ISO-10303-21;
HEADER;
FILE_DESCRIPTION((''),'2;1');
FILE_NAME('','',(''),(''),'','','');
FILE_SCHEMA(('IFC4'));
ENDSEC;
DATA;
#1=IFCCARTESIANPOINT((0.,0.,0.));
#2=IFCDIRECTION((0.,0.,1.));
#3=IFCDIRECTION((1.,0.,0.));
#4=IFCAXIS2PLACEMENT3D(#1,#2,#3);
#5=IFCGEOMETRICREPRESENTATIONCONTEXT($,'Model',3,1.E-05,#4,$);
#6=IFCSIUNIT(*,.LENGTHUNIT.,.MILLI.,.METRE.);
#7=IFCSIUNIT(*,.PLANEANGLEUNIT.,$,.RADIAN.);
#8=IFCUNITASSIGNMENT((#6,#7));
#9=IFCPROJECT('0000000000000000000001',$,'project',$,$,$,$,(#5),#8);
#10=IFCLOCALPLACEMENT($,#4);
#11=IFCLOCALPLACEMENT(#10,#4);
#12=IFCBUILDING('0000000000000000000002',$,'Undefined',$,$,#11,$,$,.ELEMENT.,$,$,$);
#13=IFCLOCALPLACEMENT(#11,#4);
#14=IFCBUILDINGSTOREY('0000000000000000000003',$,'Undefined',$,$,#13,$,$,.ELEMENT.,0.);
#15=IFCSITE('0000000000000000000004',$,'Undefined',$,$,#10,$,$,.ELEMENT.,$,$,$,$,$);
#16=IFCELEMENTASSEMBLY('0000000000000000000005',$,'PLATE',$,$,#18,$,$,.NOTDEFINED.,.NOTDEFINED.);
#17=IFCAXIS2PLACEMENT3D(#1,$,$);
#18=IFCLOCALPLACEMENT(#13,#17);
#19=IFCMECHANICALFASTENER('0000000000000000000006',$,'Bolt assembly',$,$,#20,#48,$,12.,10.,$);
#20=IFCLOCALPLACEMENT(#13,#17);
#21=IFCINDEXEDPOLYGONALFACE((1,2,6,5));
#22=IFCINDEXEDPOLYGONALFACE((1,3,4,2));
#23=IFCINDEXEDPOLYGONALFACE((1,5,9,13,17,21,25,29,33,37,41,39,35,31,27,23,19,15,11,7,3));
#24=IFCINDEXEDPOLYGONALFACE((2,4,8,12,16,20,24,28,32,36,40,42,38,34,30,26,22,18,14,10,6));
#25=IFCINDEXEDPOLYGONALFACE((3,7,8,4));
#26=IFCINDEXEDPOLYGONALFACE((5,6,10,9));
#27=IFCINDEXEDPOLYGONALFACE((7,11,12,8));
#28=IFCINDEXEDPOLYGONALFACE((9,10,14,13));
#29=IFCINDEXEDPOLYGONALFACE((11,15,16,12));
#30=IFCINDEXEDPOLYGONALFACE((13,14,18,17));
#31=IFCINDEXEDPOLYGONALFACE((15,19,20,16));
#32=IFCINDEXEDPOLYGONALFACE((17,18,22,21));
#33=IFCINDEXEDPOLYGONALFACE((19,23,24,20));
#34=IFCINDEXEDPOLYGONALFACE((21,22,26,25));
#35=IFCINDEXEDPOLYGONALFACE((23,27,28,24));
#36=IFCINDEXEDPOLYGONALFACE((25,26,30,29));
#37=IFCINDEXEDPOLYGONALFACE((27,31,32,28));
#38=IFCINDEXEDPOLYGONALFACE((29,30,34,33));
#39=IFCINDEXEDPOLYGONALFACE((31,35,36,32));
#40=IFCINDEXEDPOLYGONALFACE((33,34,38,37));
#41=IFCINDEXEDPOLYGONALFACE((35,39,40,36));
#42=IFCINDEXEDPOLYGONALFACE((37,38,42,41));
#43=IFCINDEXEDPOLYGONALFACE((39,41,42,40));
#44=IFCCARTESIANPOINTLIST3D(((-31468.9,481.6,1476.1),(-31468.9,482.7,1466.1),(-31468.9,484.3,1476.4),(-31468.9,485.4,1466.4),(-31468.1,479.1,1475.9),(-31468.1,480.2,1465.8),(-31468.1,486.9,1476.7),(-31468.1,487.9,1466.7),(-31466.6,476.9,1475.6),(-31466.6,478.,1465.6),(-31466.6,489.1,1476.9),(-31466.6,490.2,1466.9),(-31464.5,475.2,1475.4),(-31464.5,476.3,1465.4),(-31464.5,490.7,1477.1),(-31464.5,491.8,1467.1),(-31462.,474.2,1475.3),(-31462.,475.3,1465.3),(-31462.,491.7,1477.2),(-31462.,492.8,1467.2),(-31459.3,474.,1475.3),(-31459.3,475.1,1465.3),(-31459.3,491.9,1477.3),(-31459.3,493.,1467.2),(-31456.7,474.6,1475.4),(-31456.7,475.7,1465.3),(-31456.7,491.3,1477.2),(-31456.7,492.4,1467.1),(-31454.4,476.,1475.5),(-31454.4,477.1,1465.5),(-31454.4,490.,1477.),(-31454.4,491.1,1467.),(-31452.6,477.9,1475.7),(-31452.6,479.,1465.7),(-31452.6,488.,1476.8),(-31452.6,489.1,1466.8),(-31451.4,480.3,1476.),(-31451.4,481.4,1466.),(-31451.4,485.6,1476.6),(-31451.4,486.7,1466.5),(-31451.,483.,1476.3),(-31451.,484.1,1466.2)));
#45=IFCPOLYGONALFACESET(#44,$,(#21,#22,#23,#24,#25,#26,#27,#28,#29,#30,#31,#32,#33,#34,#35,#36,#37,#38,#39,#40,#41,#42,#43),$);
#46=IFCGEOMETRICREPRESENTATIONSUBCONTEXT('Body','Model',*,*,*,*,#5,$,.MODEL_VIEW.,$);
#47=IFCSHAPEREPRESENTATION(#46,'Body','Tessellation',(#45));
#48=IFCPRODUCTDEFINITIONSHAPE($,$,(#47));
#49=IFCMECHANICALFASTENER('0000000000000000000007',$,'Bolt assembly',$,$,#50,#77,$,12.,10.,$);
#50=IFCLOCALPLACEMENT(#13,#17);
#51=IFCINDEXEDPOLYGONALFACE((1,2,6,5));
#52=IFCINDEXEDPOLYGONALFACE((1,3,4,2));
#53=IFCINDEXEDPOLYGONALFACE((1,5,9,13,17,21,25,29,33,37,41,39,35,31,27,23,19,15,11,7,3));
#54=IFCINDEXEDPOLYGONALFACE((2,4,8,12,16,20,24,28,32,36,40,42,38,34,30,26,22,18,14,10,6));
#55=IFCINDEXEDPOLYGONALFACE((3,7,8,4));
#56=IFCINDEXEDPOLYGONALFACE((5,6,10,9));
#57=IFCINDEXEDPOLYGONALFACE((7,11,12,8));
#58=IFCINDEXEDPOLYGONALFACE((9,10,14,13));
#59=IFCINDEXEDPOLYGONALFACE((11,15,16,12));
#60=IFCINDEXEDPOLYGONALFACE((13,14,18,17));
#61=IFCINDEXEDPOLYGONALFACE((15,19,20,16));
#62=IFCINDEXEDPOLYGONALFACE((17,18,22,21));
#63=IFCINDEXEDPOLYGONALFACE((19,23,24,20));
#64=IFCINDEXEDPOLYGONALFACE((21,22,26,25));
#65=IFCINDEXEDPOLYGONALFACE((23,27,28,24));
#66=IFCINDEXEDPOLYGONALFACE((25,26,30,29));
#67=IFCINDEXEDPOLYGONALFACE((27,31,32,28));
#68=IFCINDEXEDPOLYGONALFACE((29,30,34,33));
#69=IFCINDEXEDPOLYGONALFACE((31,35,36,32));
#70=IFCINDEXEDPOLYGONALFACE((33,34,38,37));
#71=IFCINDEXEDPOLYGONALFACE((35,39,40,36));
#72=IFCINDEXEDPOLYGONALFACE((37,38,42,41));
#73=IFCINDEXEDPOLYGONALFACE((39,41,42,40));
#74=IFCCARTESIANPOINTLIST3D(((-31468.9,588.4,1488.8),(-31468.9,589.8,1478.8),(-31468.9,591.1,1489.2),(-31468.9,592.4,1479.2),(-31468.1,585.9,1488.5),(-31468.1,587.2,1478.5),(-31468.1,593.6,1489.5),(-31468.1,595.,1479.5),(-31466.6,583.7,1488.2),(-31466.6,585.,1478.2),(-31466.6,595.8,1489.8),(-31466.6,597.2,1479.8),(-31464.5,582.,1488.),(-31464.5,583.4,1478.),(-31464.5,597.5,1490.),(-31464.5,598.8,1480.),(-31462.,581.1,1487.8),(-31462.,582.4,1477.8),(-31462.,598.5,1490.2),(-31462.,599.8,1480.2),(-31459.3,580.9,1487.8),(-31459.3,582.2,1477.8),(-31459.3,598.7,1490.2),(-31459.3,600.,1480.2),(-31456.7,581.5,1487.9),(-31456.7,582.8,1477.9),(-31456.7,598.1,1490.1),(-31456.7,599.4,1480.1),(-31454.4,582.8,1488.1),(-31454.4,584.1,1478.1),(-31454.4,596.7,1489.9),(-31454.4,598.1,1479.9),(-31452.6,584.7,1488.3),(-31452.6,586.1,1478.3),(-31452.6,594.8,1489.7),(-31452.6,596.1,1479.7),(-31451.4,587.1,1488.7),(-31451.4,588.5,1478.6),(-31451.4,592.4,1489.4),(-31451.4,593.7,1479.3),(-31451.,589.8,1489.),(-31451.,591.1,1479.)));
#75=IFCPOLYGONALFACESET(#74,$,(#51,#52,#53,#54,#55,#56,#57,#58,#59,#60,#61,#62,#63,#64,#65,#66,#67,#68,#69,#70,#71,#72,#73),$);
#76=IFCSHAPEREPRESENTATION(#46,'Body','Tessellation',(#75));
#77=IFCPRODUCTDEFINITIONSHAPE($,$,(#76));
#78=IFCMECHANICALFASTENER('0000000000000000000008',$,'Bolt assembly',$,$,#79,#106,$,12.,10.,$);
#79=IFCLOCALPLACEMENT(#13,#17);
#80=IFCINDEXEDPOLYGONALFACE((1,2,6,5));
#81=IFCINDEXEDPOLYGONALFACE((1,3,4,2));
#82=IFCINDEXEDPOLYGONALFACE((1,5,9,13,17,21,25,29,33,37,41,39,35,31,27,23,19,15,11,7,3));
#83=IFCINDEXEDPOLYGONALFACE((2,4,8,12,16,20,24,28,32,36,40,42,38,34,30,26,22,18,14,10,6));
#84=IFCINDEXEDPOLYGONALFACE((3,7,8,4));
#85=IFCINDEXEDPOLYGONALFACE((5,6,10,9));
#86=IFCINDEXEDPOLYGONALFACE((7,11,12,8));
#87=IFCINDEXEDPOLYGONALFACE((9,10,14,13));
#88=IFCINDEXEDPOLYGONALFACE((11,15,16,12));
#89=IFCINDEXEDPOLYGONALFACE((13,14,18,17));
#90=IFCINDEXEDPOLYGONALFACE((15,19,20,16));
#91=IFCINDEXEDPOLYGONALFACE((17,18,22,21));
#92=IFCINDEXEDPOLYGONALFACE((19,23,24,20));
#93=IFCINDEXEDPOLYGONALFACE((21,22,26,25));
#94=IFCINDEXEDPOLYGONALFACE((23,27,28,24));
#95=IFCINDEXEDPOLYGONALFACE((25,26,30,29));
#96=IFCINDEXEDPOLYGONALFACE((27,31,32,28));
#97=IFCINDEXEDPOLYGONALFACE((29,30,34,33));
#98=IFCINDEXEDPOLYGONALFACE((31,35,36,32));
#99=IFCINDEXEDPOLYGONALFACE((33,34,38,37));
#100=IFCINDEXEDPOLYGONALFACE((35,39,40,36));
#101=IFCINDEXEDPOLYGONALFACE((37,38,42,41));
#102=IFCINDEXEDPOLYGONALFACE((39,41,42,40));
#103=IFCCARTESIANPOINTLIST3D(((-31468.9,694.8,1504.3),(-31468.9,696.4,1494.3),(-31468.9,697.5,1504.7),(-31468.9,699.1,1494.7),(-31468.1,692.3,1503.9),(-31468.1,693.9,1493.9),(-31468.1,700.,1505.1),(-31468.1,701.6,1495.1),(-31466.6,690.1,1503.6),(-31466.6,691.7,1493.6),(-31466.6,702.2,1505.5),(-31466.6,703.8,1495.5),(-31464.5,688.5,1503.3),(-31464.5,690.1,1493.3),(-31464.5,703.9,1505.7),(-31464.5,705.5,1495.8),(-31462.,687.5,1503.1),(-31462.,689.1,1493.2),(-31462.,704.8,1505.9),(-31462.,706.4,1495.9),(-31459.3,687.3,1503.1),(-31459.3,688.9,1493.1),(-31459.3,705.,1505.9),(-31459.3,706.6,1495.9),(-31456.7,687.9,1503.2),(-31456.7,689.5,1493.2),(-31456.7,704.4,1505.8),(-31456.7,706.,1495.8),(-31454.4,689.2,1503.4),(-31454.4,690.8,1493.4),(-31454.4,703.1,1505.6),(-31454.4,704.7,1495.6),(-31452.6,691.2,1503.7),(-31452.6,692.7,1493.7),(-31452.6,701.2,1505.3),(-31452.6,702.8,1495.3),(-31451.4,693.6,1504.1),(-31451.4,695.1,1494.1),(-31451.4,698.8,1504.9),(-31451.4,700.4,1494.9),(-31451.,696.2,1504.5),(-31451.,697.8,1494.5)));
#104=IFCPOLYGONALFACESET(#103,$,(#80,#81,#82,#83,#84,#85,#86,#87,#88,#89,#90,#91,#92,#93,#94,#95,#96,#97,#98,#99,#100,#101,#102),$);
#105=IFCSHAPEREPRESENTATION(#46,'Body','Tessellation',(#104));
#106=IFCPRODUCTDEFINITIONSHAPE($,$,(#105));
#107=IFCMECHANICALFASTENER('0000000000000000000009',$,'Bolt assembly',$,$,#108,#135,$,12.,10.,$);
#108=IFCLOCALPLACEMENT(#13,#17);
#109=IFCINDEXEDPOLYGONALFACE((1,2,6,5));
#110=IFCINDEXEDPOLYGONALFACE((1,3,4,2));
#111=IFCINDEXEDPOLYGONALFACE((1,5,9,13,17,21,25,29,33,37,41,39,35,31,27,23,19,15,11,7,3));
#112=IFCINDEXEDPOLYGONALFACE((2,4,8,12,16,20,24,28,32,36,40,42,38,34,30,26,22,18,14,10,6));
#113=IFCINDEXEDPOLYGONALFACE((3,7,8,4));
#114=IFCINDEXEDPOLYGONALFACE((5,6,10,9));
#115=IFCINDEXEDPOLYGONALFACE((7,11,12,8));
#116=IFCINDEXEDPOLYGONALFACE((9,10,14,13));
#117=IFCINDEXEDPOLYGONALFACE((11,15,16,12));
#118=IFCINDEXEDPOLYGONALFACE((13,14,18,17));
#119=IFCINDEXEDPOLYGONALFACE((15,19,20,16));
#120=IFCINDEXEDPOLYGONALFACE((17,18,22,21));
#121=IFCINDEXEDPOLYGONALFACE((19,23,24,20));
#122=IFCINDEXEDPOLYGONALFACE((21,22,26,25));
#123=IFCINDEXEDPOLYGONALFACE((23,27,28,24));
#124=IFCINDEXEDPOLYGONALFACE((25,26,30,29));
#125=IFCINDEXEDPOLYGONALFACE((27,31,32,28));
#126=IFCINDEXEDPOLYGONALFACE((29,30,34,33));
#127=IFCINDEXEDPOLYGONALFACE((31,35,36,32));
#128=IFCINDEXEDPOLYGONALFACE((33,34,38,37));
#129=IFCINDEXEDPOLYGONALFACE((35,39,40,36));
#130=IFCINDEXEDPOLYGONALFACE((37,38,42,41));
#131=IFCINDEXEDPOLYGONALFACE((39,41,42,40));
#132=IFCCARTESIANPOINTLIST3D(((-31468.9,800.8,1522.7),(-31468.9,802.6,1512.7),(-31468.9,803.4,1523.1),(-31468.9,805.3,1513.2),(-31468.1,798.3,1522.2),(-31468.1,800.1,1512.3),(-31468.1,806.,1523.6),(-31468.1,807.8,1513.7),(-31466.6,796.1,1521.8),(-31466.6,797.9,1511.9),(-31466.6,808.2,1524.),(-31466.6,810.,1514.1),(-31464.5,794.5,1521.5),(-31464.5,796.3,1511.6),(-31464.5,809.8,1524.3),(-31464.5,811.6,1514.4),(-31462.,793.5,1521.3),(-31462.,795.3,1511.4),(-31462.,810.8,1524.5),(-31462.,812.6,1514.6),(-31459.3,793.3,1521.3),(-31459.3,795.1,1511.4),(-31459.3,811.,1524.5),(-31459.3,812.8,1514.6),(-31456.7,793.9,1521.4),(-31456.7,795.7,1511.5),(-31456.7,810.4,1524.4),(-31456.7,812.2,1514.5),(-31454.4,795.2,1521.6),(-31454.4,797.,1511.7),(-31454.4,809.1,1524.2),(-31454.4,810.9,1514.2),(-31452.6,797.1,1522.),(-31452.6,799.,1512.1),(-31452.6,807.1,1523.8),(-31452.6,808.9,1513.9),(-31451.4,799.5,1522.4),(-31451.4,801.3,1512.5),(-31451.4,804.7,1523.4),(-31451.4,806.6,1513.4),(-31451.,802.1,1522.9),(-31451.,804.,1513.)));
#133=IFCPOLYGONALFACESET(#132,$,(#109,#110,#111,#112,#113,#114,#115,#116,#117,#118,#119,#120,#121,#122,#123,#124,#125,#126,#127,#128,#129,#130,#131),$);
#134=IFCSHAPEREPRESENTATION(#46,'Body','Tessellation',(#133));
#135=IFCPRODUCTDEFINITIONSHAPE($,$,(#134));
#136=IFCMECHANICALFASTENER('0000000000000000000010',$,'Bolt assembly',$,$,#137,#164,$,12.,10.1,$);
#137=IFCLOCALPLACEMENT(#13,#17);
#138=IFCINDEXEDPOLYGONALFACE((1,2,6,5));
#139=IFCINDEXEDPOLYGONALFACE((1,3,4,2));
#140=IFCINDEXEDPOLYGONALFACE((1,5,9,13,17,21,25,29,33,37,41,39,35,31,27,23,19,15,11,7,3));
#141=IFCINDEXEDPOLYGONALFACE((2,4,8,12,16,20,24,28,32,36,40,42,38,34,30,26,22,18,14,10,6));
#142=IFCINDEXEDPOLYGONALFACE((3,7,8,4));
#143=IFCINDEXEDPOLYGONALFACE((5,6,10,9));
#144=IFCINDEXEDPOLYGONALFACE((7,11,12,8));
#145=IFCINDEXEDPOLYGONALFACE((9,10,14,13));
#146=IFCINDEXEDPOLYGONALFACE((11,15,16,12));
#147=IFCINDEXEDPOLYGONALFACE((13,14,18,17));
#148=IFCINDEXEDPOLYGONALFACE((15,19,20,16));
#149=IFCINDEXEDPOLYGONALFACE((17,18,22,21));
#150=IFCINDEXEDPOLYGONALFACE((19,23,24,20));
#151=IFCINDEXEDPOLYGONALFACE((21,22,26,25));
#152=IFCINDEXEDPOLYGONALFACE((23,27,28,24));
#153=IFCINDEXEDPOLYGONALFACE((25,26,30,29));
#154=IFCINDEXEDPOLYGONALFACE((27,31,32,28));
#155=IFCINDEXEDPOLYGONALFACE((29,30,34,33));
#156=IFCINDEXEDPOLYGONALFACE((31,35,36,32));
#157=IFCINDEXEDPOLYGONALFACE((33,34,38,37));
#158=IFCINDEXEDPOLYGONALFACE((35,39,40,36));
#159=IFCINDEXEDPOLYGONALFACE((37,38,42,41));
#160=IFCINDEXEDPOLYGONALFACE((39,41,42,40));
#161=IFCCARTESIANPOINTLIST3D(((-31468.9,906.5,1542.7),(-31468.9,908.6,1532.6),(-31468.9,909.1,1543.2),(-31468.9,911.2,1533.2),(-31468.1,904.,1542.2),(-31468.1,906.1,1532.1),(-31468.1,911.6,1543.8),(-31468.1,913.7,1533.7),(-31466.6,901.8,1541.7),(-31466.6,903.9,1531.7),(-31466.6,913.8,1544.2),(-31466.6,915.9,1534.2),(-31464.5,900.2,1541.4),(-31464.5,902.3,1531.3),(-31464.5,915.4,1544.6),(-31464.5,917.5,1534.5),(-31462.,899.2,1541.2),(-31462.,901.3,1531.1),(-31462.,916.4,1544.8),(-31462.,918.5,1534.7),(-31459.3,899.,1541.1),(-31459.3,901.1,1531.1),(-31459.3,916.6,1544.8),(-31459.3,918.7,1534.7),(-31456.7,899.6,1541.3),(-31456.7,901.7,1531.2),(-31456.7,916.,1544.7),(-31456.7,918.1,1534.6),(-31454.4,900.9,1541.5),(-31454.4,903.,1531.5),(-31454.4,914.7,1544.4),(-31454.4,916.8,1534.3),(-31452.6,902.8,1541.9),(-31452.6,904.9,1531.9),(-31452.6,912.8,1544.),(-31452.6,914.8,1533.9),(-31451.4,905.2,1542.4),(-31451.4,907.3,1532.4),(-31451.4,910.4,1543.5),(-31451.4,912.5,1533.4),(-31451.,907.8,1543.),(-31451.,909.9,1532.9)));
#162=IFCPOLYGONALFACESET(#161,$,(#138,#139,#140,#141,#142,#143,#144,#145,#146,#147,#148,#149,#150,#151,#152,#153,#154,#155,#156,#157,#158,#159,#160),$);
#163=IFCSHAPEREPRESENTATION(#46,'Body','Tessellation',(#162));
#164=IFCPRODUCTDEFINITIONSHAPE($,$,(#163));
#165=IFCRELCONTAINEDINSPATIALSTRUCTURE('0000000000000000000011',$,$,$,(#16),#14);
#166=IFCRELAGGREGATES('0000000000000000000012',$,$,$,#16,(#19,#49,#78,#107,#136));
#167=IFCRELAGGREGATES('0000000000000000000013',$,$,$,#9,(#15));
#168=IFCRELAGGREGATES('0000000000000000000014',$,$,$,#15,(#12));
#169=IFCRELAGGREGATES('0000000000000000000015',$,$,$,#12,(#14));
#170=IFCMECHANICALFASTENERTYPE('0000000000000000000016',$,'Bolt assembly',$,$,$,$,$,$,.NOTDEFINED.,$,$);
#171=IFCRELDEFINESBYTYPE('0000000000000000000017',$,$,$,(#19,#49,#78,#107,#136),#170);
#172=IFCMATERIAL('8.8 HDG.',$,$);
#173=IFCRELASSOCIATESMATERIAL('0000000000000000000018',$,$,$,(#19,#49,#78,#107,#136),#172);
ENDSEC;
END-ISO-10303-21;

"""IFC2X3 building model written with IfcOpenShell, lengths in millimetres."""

from ifc_helpers import new_model, si_unit, frame, origin_with_axes, origin_2d_with_axis, place, context, subcontext, project, spatial, circle, extrude, source, transform, mapped, material, type_object, element, aggregate, save


model = new_model("IFC2X3")

# Units and contexts
model_context = context("Model", 3, precision=1e-05, world=origin_with_axes())
body_context = subcontext(model_context, "Body", "Model", "MODEL_VIEW")
ifc_project = project(units=[si_unit("LENGTHUNIT", "METRE", prefix="MILLI"), si_unit("PLANEANGLEUNIT", "RADIAN")], contexts=[model_context])

# Site, building, storey
site_placement = place(None, origin_with_axes())
site = spatial("IfcSite", under=ifc_project, at=site_placement, Name="Undefined", CompositionType="ELEMENT")
building_placement = place(site_placement, origin_with_axes())
building = spatial("IfcBuilding", under=site, at=building_placement, Name="Undefined", CompositionType="ELEMENT")
storey_placement = place(building_placement, origin_with_axes())
storey = spatial("IfcBuildingStorey", under=building, at=storey_placement, Name="Undefined", CompositionType="ELEMENT", Elevation=0.0)

# Element assembly, mechanical fasteners
assembly_placement = place(storey_placement, origin_with_axes())
assembly = element("IfcElementAssembly", 1, at=assembly_placement, inside=storey, Name="PLATE", AssemblyPlace="NOTDEFINED", PredefinedType="NOTDEFINED")
ifc_material_1 = material(Name="8.8 HDG.")
mechanical_fastener_type = type_object("IfcMechanicalFastenerType", Name="Bolt assembly")
shared_shape_1 = source(origin_with_axes(), body_context, "Body", "SweptSolid", [
    extrude(circle(Radius=9.0, at=origin_2d_with_axis()), frame((0.0, 0.8, 0.0), z_axis=(0.0, 1.0, 0.0), x_axis=(1.0, 0.0, 0.0)), (0.0, 0.0, 1.0), 10.1),
])
mechanical_fastener_1_placement = place(assembly_placement, frame((-31460.0, 484.2, 1465.4), z_axis=(0.000001, -0.994093, -0.108533), x_axis=(1.0, 0.000001, -0.000001)))
mechanical_fastener_1 = element("IfcMechanicalFastener", 2, at=mechanical_fastener_1_placement, type_object=mechanical_fastener_type, material=ifc_material_1, Name="Bolt assembly", NominalDiameter=12.0, NominalLength=10.0, context=body_context, shape_type="MappedRepresentation", body=[
    mapped(shared_shape_1, transform((0.0, 0.0, 0.0))),
])
shared_shape_2 = source(origin_with_axes(), body_context, "Body", "SweptSolid", [
    extrude(circle(Radius=9.0, at=origin_2d_with_axis()), frame((0.0, 0.6, 0.0), z_axis=(0.0, 1.0, 0.0), x_axis=(1.0, 0.0, 0.0)), (0.0, 0.0, 1.0), 10.1),
])
mechanical_fastener_2_placement = place(assembly_placement, frame((-31460.0, 591.2, 1478.4), z_axis=(0.000001, -0.99118, -0.132523), x_axis=(1.0, 0.000001, 0.0)))
mechanical_fastener_2 = element("IfcMechanicalFastener", 3, at=mechanical_fastener_2_placement, type_object=mechanical_fastener_type, material=ifc_material_1, Name="Bolt assembly", NominalDiameter=12.0, NominalLength=10.0, context=body_context, shape_type="MappedRepresentation", body=[
    mapped(shared_shape_2, transform((0.0, 0.0, 0.0))),
])
shared_shape_3 = source(origin_with_axes(), body_context, "Body", "SweptSolid", [
    extrude(circle(Radius=9.0, at=origin_2d_with_axis()), frame((0.0, 0.6, 0.0), z_axis=(0.0, 1.0, 0.0), x_axis=(1.0, 0.0, 0.0)), (0.0, 0.0, 1.0), 10.1),
])
mechanical_fastener_3_placement = place(assembly_placement, frame((-31460.0, 697.8, 1494.0), z_axis=(0.000001, -0.987688, -0.156435), x_axis=(1.0, 0.000001, 0.0)))
mechanical_fastener_3 = element("IfcMechanicalFastener", 4, at=mechanical_fastener_3_placement, type_object=mechanical_fastener_type, material=ifc_material_1, Name="Bolt assembly", NominalDiameter=12.0, NominalLength=10.0, context=body_context, shape_type="MappedRepresentation", body=[
    mapped(shared_shape_3, transform((0.0, 0.0, 0.0))),
])
shared_shape_4 = source(origin_with_axes(), body_context, "Body", "SweptSolid", [
    extrude(circle(Radius=9.0, at=origin_2d_with_axis()), frame((0.0, 0.9, 0.0), z_axis=(0.0, 1.0, 0.0), x_axis=(1.0, 0.0, 0.0)), (0.0, 0.0, 1.0), 10.1),
])
mechanical_fastener_4_placement = place(assembly_placement, frame((-31460.0, 804.1, 1512.1), z_axis=(0.000001, -0.98362, -0.180255), x_axis=(1.0, 0.000001, 0.0)))
mechanical_fastener_4 = element("IfcMechanicalFastener", 5, at=mechanical_fastener_4_placement, type_object=mechanical_fastener_type, material=ifc_material_1, Name="Bolt assembly", NominalDiameter=12.0, NominalLength=10.0, context=body_context, shape_type="MappedRepresentation", body=[
    mapped(shared_shape_4, transform((0.0, 0.0, 0.0))),
])
shared_shape_5 = source(origin_with_axes(), body_context, "Body", "SweptSolid", [
    extrude(circle(Radius=9.0, at=origin_2d_with_axis()), frame((0.0, 0.1, 0.0), z_axis=(0.0, 1.0, 0.0), x_axis=(1.0, 0.0, 0.0)), (0.0, 0.0, 1.0), 10.3),
])
mechanical_fastener_5_placement = place(assembly_placement, frame((-31460.0, 909.9, 1532.8), z_axis=(0.000001, -0.978977, -0.203971), x_axis=(1.0, 0.000001, 0.0)))
mechanical_fastener_5 = element("IfcMechanicalFastener", 6, at=mechanical_fastener_5_placement, type_object=mechanical_fastener_type, material=ifc_material_1, Name="Bolt assembly", NominalDiameter=12.0, NominalLength=10.1, context=body_context, shape_type="MappedRepresentation", body=[
    mapped(shared_shape_5, transform((0.0, 0.0, 0.0))),
])
aggregate(assembly, [mechanical_fastener_1, mechanical_fastener_2, mechanical_fastener_3, mechanical_fastener_4, mechanical_fastener_5])

save(model, "model.ifc")
